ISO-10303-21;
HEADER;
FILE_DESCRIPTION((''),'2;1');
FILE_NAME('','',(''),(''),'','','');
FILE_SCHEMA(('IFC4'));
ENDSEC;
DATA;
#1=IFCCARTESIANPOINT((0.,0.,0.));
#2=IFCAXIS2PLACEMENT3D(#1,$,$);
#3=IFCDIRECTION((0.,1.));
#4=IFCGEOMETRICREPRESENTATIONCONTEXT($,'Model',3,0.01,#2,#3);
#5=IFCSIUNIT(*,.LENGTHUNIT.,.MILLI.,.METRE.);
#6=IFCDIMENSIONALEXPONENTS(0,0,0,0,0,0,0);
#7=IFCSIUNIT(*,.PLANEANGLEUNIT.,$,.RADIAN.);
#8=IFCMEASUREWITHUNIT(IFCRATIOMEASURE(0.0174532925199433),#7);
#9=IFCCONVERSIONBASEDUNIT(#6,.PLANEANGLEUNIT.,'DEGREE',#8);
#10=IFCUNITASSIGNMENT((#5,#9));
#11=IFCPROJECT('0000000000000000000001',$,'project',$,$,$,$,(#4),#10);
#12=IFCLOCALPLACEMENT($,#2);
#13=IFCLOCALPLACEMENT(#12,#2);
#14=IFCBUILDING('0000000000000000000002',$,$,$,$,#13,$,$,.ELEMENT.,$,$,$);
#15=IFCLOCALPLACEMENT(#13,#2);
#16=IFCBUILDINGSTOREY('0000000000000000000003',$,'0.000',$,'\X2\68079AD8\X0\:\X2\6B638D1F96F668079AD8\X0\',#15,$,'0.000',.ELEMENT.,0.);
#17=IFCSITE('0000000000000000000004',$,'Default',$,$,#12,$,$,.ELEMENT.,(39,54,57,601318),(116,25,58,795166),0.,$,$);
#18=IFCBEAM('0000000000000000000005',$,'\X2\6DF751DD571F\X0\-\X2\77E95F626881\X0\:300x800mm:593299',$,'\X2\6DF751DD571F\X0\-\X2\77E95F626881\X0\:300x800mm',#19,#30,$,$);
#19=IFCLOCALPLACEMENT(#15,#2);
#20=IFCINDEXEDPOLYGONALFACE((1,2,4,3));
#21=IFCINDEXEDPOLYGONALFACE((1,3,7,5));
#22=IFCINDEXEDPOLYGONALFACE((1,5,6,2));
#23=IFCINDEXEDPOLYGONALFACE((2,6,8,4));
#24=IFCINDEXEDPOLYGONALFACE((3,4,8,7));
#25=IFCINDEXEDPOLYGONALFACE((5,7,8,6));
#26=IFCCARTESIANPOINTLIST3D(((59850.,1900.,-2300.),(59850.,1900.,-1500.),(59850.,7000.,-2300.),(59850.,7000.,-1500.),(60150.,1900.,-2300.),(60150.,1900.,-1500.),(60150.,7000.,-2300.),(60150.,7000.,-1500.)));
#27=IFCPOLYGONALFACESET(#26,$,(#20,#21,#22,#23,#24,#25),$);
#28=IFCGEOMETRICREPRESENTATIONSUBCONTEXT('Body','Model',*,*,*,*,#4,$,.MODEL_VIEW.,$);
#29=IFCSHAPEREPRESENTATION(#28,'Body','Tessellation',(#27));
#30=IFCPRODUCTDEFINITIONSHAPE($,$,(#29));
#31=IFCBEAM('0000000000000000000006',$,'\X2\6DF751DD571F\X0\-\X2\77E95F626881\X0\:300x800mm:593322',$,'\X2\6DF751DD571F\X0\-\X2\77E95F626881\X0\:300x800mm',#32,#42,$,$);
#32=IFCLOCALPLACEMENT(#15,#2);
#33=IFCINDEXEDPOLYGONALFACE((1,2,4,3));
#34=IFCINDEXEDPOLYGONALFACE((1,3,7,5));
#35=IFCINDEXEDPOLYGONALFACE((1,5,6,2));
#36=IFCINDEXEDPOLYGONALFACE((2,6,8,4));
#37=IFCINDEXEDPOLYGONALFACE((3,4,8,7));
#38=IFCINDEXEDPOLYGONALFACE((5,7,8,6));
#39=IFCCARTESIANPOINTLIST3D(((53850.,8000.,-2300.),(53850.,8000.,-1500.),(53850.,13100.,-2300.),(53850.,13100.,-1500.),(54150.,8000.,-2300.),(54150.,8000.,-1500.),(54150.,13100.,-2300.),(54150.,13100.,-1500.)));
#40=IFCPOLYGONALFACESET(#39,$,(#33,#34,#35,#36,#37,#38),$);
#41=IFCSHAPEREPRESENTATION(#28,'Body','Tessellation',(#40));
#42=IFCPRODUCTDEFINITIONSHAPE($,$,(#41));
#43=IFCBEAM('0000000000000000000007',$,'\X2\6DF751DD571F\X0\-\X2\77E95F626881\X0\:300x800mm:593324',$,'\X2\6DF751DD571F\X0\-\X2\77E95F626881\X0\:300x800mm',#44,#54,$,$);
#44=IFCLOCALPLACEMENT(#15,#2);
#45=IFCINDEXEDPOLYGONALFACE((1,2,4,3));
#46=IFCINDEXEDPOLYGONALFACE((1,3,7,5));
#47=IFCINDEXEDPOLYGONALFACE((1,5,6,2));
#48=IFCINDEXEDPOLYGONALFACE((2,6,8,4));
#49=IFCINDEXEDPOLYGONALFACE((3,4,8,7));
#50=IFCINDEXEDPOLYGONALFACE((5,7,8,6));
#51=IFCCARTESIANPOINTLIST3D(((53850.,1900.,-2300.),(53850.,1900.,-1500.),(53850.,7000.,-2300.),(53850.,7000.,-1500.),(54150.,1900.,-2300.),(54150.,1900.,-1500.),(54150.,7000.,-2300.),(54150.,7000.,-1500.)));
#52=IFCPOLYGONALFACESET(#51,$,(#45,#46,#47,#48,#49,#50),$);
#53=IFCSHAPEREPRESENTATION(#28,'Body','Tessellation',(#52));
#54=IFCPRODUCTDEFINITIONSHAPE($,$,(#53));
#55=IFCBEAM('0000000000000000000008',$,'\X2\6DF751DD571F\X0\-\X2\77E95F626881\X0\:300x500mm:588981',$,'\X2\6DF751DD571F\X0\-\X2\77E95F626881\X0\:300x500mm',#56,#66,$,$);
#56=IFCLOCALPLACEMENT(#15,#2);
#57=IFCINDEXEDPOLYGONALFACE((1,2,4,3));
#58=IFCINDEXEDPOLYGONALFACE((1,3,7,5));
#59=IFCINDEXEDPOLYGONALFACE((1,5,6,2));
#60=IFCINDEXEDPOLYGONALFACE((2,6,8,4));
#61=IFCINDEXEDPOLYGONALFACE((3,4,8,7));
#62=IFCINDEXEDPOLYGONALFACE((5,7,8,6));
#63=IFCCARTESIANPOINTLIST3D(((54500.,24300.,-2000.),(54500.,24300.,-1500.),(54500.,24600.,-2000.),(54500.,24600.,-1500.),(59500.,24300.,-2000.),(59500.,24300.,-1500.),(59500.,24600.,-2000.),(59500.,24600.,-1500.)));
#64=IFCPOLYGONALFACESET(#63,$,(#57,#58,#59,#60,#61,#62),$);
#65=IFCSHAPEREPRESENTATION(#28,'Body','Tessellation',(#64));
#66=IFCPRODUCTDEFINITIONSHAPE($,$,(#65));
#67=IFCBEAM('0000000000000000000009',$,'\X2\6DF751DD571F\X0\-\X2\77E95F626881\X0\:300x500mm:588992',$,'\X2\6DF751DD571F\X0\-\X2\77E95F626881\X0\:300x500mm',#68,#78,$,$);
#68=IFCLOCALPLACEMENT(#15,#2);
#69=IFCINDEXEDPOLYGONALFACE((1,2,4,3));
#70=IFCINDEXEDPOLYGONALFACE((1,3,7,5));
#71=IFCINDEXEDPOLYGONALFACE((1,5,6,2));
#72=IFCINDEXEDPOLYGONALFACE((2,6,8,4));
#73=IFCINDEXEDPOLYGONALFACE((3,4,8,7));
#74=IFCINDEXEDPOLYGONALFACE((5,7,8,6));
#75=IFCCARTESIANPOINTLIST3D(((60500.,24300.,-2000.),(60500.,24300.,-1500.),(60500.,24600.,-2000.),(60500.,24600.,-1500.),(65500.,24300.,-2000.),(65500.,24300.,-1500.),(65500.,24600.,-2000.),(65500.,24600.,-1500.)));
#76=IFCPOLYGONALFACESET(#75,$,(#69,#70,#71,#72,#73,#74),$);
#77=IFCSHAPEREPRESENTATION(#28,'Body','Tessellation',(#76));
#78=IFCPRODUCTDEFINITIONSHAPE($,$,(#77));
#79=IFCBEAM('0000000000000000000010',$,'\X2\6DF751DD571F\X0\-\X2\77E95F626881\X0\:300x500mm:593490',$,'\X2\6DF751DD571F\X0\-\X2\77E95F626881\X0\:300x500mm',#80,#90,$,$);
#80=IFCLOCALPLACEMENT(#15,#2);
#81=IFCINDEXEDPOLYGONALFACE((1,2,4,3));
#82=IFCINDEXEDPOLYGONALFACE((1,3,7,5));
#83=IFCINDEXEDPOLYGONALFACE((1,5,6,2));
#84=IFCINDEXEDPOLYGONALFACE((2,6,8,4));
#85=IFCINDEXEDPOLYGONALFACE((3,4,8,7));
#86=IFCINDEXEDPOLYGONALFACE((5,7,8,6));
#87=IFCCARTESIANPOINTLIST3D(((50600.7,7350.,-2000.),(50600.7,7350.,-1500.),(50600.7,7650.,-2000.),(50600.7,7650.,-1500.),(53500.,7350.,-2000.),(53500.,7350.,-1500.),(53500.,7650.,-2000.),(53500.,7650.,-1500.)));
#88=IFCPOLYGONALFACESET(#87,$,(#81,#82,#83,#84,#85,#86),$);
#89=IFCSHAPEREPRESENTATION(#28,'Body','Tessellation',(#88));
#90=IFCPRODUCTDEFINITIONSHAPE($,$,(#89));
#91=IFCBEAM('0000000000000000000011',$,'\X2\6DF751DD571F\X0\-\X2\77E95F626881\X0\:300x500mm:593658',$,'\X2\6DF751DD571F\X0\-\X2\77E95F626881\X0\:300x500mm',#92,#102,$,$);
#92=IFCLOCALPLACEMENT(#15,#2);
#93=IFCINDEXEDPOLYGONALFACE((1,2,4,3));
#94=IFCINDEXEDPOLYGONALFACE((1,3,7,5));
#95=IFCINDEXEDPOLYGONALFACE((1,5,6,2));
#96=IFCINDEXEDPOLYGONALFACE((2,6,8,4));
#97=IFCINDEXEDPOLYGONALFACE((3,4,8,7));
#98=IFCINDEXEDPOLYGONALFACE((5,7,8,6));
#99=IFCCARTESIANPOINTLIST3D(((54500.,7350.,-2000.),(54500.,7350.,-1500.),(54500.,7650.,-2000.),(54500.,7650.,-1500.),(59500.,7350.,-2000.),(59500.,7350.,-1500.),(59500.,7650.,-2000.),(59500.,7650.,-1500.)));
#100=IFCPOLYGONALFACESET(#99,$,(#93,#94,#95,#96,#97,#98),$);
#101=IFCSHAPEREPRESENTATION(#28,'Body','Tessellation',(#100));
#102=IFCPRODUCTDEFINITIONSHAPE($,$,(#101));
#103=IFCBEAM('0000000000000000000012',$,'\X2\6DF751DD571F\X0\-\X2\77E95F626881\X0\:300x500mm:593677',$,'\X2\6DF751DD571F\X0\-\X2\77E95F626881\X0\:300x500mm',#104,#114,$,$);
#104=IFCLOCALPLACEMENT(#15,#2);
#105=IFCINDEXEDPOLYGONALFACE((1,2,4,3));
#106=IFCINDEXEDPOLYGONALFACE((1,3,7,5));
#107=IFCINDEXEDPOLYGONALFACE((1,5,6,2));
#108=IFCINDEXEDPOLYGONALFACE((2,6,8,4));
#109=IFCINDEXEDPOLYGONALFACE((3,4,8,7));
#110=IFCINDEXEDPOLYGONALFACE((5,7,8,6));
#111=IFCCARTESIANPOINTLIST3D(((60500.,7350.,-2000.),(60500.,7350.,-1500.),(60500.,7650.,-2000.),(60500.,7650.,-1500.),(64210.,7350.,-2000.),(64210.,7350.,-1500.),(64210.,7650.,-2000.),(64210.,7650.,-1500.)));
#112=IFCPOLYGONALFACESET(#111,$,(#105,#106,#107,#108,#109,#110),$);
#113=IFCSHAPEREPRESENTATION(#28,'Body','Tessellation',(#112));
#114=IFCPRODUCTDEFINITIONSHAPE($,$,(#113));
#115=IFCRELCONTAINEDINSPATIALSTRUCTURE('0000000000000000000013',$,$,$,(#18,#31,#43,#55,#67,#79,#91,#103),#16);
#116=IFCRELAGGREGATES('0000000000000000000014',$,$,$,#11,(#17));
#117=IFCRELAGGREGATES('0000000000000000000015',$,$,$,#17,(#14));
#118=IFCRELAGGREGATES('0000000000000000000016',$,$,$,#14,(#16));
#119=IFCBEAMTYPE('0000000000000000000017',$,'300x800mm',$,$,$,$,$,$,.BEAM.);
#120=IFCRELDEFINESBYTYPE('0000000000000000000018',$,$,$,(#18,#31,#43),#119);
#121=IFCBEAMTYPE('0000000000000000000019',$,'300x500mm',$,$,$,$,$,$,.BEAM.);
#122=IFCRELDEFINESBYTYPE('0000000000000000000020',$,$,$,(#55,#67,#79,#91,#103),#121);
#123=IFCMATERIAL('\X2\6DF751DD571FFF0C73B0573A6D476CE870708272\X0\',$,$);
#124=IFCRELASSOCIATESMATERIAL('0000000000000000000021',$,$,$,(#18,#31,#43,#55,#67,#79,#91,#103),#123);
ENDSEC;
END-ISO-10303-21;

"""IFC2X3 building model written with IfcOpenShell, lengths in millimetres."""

from ifc_helpers import new_model, entity, si_unit, converted_unit, direction, frame, frame_2d, origin, place, context, subcontext, project, spatial, rectangle, extrude, material, type_object, element, save


model = new_model("IFC2X3")

# Units and contexts
model_context = context("Model", 3, precision=0.01, world=origin(), true_north=direction((0.0, 1.0)))
body_context = subcontext(model_context, "Body", "Model", "MODEL_VIEW")
ifc_project = project(units=[si_unit("LENGTHUNIT", "METRE", prefix="MILLI"), converted_unit("PLANEANGLEUNIT", "DEGREE", entity("IfcRatioMeasure", 0.0174532925199433), si_unit("PLANEANGLEUNIT", "RADIAN"), dimensions=[0, 0, 0, 0, 0, 0, 0])], contexts=[model_context])

# Site, building, storey
site_placement = place(None, origin())
site = spatial("IfcSite", under=ifc_project, at=site_placement, Name="Default", CompositionType="ELEMENT", RefLatitude=(39, 54, 57, 601318), RefLongitude=(116, 25, 58, 795166), RefElevation=0.0)
building_placement = place(site_placement, origin())
building = spatial("IfcBuilding", under=site, at=building_placement, CompositionType="ELEMENT")
storey_placement = place(building_placement, origin())
storey = spatial("IfcBuildingStorey", under=building, at=storey_placement, Name="0.000", ObjectType="标高:正负零标高", LongName="0.000", CompositionType="ELEMENT", Elevation=0.0)

# Shared definitions
ifc_material = material(Name="混凝土，现场浇注灰色")

# Beams
beam_type_1 = type_object("IfcBeamType", Name="300x800mm", PredefinedType="BEAM")
beam_1_placement = place(storey_placement, frame((60000.0, 7000.0, -1500.0), z_axis=(0.0, 0.0, 1.0), x_axis=(0.0, -1.0, 0.0)))
element("IfcBeam", 1, at=beam_1_placement, inside=storey, type_object=beam_type_1, material=ifc_material, Name="混凝土-矩形梁:300x800mm:593299", ObjectType="混凝土-矩形梁:300x800mm", context=body_context, shape_type="SweptSolid", body=[
    extrude(rectangle(XDim=800.0, YDim=300.0, at=frame_2d((0.0, 0.0), x_axis=(1.0, 0.0))), frame((0.0, 0.0, -400.0), z_axis=(1.0, 0.0, 0.0), x_axis=(0.0, 0.0, -1.0)), (0.0, 0.0, 1.0), 5100.0),
])
beam_2_placement = place(storey_placement, frame((54000.0, 13100.0, -1500.0), z_axis=(0.0, 0.0, 1.0), x_axis=(0.0, -1.0, 0.0)))
element("IfcBeam", 2, at=beam_2_placement, inside=storey, type_object=beam_type_1, material=ifc_material, Name="混凝土-矩形梁:300x800mm:593322", ObjectType="混凝土-矩形梁:300x800mm", context=body_context, shape_type="SweptSolid", body=[
    extrude(rectangle(XDim=800.0, YDim=300.0, at=frame_2d((0.0, 0.0), x_axis=(1.0, 0.0))), frame((0.0, 0.0, -400.0), z_axis=(1.0, 0.0, 0.0), x_axis=(0.0, 0.0, -1.0)), (0.0, 0.0, 1.0), 5100.0),
])
beam_3_placement = place(storey_placement, frame((54000.0, 7000.0, -1500.0), z_axis=(0.0, 0.0, 1.0), x_axis=(0.0, -1.0, 0.0)))
element("IfcBeam", 3, at=beam_3_placement, inside=storey, type_object=beam_type_1, material=ifc_material, Name="混凝土-矩形梁:300x800mm:593324", ObjectType="混凝土-矩形梁:300x800mm", context=body_context, shape_type="SweptSolid", body=[
    extrude(rectangle(XDim=800.0, YDim=300.0, at=frame_2d((0.0, 0.0), x_axis=(1.0, 0.0))), frame((0.0, 0.0, -400.0), z_axis=(1.0, 0.0, 0.0), x_axis=(0.0, 0.0, -1.0)), (0.0, 0.0, 1.0), 5100.0),
])
beam_type_2 = type_object("IfcBeamType", Name="300x500mm", PredefinedType="BEAM")
for number, where, name in (
    (4, (54500.0, 24450.0, -1500.0), "混凝土-矩形梁:300x500mm:588981"),
    (5, (60500.0, 24450.0, -1500.0), "混凝土-矩形梁:300x500mm:588992"),
):
    element("IfcBeam", number, at=place(storey_placement, frame(where)), inside=storey, type_object=beam_type_2, material=ifc_material, Name=name, ObjectType="混凝土-矩形梁:300x500mm", context=body_context, shape_type="SweptSolid", body=[
        extrude(rectangle(XDim=500.0, YDim=300.0, at=frame_2d((0.0, 0.0), x_axis=(1.0, 0.0))), frame((0.0, 0.0, -250.0), z_axis=(1.0, 0.0, 0.0), x_axis=(0.0, 0.0, -1.0)), (0.0, 0.0, 1.0), 5000.0),
    ])
beam_4_placement = place(storey_placement, frame((50100.0, 7500.0, -1500.0)))
element("IfcBeam", 6, at=beam_4_placement, inside=storey, type_object=beam_type_2, material=ifc_material, Name="混凝土-矩形梁:300x500mm:593490", ObjectType="混凝土-矩形梁:300x500mm", context=body_context, shape_type="SweptSolid", body=[
    extrude(rectangle(XDim=500.0, YDim=300.0, at=frame_2d((0.0, 0.0), x_axis=(1.0, 0.0))), frame((500.7, 0.0, -250.0), z_axis=(1.0, 0.0, 0.0), x_axis=(0.0, 0.0, -1.0)), (0.0, 0.0, 1.0), 2899.3),
])
beam_5_placement = place(storey_placement, frame((54500.0, 7500.0, -1500.0)))
element("IfcBeam", 7, at=beam_5_placement, inside=storey, type_object=beam_type_2, material=ifc_material, Name="混凝土-矩形梁:300x500mm:593658", ObjectType="混凝土-矩形梁:300x500mm", context=body_context, shape_type="SweptSolid", body=[
    extrude(rectangle(XDim=500.0, YDim=300.0, at=frame_2d((0.0, 0.0), x_axis=(1.0, 0.0))), frame((0.0, 0.0, -250.0), z_axis=(1.0, 0.0, 0.0), x_axis=(0.0, 0.0, -1.0)), (0.0, 0.0, 1.0), 5000.0),
])
beam_6_placement = place(storey_placement, frame((60500.0, 7500.0, -1500.0)))
element("IfcBeam", 8, at=beam_6_placement, inside=storey, type_object=beam_type_2, material=ifc_material, Name="混凝土-矩形梁:300x500mm:593677", ObjectType="混凝土-矩形梁:300x500mm", context=body_context, shape_type="SweptSolid", body=[
    extrude(rectangle(XDim=500.0, YDim=300.0, at=frame_2d((0.0, 0.0), x_axis=(1.0, 0.0))), frame((0.0, 0.0, -250.0), z_axis=(1.0, 0.0, 0.0), x_axis=(0.0, 0.0, -1.0)), (0.0, 0.0, 1.0), 3710.0),
])

save(model, "model.ifc")
